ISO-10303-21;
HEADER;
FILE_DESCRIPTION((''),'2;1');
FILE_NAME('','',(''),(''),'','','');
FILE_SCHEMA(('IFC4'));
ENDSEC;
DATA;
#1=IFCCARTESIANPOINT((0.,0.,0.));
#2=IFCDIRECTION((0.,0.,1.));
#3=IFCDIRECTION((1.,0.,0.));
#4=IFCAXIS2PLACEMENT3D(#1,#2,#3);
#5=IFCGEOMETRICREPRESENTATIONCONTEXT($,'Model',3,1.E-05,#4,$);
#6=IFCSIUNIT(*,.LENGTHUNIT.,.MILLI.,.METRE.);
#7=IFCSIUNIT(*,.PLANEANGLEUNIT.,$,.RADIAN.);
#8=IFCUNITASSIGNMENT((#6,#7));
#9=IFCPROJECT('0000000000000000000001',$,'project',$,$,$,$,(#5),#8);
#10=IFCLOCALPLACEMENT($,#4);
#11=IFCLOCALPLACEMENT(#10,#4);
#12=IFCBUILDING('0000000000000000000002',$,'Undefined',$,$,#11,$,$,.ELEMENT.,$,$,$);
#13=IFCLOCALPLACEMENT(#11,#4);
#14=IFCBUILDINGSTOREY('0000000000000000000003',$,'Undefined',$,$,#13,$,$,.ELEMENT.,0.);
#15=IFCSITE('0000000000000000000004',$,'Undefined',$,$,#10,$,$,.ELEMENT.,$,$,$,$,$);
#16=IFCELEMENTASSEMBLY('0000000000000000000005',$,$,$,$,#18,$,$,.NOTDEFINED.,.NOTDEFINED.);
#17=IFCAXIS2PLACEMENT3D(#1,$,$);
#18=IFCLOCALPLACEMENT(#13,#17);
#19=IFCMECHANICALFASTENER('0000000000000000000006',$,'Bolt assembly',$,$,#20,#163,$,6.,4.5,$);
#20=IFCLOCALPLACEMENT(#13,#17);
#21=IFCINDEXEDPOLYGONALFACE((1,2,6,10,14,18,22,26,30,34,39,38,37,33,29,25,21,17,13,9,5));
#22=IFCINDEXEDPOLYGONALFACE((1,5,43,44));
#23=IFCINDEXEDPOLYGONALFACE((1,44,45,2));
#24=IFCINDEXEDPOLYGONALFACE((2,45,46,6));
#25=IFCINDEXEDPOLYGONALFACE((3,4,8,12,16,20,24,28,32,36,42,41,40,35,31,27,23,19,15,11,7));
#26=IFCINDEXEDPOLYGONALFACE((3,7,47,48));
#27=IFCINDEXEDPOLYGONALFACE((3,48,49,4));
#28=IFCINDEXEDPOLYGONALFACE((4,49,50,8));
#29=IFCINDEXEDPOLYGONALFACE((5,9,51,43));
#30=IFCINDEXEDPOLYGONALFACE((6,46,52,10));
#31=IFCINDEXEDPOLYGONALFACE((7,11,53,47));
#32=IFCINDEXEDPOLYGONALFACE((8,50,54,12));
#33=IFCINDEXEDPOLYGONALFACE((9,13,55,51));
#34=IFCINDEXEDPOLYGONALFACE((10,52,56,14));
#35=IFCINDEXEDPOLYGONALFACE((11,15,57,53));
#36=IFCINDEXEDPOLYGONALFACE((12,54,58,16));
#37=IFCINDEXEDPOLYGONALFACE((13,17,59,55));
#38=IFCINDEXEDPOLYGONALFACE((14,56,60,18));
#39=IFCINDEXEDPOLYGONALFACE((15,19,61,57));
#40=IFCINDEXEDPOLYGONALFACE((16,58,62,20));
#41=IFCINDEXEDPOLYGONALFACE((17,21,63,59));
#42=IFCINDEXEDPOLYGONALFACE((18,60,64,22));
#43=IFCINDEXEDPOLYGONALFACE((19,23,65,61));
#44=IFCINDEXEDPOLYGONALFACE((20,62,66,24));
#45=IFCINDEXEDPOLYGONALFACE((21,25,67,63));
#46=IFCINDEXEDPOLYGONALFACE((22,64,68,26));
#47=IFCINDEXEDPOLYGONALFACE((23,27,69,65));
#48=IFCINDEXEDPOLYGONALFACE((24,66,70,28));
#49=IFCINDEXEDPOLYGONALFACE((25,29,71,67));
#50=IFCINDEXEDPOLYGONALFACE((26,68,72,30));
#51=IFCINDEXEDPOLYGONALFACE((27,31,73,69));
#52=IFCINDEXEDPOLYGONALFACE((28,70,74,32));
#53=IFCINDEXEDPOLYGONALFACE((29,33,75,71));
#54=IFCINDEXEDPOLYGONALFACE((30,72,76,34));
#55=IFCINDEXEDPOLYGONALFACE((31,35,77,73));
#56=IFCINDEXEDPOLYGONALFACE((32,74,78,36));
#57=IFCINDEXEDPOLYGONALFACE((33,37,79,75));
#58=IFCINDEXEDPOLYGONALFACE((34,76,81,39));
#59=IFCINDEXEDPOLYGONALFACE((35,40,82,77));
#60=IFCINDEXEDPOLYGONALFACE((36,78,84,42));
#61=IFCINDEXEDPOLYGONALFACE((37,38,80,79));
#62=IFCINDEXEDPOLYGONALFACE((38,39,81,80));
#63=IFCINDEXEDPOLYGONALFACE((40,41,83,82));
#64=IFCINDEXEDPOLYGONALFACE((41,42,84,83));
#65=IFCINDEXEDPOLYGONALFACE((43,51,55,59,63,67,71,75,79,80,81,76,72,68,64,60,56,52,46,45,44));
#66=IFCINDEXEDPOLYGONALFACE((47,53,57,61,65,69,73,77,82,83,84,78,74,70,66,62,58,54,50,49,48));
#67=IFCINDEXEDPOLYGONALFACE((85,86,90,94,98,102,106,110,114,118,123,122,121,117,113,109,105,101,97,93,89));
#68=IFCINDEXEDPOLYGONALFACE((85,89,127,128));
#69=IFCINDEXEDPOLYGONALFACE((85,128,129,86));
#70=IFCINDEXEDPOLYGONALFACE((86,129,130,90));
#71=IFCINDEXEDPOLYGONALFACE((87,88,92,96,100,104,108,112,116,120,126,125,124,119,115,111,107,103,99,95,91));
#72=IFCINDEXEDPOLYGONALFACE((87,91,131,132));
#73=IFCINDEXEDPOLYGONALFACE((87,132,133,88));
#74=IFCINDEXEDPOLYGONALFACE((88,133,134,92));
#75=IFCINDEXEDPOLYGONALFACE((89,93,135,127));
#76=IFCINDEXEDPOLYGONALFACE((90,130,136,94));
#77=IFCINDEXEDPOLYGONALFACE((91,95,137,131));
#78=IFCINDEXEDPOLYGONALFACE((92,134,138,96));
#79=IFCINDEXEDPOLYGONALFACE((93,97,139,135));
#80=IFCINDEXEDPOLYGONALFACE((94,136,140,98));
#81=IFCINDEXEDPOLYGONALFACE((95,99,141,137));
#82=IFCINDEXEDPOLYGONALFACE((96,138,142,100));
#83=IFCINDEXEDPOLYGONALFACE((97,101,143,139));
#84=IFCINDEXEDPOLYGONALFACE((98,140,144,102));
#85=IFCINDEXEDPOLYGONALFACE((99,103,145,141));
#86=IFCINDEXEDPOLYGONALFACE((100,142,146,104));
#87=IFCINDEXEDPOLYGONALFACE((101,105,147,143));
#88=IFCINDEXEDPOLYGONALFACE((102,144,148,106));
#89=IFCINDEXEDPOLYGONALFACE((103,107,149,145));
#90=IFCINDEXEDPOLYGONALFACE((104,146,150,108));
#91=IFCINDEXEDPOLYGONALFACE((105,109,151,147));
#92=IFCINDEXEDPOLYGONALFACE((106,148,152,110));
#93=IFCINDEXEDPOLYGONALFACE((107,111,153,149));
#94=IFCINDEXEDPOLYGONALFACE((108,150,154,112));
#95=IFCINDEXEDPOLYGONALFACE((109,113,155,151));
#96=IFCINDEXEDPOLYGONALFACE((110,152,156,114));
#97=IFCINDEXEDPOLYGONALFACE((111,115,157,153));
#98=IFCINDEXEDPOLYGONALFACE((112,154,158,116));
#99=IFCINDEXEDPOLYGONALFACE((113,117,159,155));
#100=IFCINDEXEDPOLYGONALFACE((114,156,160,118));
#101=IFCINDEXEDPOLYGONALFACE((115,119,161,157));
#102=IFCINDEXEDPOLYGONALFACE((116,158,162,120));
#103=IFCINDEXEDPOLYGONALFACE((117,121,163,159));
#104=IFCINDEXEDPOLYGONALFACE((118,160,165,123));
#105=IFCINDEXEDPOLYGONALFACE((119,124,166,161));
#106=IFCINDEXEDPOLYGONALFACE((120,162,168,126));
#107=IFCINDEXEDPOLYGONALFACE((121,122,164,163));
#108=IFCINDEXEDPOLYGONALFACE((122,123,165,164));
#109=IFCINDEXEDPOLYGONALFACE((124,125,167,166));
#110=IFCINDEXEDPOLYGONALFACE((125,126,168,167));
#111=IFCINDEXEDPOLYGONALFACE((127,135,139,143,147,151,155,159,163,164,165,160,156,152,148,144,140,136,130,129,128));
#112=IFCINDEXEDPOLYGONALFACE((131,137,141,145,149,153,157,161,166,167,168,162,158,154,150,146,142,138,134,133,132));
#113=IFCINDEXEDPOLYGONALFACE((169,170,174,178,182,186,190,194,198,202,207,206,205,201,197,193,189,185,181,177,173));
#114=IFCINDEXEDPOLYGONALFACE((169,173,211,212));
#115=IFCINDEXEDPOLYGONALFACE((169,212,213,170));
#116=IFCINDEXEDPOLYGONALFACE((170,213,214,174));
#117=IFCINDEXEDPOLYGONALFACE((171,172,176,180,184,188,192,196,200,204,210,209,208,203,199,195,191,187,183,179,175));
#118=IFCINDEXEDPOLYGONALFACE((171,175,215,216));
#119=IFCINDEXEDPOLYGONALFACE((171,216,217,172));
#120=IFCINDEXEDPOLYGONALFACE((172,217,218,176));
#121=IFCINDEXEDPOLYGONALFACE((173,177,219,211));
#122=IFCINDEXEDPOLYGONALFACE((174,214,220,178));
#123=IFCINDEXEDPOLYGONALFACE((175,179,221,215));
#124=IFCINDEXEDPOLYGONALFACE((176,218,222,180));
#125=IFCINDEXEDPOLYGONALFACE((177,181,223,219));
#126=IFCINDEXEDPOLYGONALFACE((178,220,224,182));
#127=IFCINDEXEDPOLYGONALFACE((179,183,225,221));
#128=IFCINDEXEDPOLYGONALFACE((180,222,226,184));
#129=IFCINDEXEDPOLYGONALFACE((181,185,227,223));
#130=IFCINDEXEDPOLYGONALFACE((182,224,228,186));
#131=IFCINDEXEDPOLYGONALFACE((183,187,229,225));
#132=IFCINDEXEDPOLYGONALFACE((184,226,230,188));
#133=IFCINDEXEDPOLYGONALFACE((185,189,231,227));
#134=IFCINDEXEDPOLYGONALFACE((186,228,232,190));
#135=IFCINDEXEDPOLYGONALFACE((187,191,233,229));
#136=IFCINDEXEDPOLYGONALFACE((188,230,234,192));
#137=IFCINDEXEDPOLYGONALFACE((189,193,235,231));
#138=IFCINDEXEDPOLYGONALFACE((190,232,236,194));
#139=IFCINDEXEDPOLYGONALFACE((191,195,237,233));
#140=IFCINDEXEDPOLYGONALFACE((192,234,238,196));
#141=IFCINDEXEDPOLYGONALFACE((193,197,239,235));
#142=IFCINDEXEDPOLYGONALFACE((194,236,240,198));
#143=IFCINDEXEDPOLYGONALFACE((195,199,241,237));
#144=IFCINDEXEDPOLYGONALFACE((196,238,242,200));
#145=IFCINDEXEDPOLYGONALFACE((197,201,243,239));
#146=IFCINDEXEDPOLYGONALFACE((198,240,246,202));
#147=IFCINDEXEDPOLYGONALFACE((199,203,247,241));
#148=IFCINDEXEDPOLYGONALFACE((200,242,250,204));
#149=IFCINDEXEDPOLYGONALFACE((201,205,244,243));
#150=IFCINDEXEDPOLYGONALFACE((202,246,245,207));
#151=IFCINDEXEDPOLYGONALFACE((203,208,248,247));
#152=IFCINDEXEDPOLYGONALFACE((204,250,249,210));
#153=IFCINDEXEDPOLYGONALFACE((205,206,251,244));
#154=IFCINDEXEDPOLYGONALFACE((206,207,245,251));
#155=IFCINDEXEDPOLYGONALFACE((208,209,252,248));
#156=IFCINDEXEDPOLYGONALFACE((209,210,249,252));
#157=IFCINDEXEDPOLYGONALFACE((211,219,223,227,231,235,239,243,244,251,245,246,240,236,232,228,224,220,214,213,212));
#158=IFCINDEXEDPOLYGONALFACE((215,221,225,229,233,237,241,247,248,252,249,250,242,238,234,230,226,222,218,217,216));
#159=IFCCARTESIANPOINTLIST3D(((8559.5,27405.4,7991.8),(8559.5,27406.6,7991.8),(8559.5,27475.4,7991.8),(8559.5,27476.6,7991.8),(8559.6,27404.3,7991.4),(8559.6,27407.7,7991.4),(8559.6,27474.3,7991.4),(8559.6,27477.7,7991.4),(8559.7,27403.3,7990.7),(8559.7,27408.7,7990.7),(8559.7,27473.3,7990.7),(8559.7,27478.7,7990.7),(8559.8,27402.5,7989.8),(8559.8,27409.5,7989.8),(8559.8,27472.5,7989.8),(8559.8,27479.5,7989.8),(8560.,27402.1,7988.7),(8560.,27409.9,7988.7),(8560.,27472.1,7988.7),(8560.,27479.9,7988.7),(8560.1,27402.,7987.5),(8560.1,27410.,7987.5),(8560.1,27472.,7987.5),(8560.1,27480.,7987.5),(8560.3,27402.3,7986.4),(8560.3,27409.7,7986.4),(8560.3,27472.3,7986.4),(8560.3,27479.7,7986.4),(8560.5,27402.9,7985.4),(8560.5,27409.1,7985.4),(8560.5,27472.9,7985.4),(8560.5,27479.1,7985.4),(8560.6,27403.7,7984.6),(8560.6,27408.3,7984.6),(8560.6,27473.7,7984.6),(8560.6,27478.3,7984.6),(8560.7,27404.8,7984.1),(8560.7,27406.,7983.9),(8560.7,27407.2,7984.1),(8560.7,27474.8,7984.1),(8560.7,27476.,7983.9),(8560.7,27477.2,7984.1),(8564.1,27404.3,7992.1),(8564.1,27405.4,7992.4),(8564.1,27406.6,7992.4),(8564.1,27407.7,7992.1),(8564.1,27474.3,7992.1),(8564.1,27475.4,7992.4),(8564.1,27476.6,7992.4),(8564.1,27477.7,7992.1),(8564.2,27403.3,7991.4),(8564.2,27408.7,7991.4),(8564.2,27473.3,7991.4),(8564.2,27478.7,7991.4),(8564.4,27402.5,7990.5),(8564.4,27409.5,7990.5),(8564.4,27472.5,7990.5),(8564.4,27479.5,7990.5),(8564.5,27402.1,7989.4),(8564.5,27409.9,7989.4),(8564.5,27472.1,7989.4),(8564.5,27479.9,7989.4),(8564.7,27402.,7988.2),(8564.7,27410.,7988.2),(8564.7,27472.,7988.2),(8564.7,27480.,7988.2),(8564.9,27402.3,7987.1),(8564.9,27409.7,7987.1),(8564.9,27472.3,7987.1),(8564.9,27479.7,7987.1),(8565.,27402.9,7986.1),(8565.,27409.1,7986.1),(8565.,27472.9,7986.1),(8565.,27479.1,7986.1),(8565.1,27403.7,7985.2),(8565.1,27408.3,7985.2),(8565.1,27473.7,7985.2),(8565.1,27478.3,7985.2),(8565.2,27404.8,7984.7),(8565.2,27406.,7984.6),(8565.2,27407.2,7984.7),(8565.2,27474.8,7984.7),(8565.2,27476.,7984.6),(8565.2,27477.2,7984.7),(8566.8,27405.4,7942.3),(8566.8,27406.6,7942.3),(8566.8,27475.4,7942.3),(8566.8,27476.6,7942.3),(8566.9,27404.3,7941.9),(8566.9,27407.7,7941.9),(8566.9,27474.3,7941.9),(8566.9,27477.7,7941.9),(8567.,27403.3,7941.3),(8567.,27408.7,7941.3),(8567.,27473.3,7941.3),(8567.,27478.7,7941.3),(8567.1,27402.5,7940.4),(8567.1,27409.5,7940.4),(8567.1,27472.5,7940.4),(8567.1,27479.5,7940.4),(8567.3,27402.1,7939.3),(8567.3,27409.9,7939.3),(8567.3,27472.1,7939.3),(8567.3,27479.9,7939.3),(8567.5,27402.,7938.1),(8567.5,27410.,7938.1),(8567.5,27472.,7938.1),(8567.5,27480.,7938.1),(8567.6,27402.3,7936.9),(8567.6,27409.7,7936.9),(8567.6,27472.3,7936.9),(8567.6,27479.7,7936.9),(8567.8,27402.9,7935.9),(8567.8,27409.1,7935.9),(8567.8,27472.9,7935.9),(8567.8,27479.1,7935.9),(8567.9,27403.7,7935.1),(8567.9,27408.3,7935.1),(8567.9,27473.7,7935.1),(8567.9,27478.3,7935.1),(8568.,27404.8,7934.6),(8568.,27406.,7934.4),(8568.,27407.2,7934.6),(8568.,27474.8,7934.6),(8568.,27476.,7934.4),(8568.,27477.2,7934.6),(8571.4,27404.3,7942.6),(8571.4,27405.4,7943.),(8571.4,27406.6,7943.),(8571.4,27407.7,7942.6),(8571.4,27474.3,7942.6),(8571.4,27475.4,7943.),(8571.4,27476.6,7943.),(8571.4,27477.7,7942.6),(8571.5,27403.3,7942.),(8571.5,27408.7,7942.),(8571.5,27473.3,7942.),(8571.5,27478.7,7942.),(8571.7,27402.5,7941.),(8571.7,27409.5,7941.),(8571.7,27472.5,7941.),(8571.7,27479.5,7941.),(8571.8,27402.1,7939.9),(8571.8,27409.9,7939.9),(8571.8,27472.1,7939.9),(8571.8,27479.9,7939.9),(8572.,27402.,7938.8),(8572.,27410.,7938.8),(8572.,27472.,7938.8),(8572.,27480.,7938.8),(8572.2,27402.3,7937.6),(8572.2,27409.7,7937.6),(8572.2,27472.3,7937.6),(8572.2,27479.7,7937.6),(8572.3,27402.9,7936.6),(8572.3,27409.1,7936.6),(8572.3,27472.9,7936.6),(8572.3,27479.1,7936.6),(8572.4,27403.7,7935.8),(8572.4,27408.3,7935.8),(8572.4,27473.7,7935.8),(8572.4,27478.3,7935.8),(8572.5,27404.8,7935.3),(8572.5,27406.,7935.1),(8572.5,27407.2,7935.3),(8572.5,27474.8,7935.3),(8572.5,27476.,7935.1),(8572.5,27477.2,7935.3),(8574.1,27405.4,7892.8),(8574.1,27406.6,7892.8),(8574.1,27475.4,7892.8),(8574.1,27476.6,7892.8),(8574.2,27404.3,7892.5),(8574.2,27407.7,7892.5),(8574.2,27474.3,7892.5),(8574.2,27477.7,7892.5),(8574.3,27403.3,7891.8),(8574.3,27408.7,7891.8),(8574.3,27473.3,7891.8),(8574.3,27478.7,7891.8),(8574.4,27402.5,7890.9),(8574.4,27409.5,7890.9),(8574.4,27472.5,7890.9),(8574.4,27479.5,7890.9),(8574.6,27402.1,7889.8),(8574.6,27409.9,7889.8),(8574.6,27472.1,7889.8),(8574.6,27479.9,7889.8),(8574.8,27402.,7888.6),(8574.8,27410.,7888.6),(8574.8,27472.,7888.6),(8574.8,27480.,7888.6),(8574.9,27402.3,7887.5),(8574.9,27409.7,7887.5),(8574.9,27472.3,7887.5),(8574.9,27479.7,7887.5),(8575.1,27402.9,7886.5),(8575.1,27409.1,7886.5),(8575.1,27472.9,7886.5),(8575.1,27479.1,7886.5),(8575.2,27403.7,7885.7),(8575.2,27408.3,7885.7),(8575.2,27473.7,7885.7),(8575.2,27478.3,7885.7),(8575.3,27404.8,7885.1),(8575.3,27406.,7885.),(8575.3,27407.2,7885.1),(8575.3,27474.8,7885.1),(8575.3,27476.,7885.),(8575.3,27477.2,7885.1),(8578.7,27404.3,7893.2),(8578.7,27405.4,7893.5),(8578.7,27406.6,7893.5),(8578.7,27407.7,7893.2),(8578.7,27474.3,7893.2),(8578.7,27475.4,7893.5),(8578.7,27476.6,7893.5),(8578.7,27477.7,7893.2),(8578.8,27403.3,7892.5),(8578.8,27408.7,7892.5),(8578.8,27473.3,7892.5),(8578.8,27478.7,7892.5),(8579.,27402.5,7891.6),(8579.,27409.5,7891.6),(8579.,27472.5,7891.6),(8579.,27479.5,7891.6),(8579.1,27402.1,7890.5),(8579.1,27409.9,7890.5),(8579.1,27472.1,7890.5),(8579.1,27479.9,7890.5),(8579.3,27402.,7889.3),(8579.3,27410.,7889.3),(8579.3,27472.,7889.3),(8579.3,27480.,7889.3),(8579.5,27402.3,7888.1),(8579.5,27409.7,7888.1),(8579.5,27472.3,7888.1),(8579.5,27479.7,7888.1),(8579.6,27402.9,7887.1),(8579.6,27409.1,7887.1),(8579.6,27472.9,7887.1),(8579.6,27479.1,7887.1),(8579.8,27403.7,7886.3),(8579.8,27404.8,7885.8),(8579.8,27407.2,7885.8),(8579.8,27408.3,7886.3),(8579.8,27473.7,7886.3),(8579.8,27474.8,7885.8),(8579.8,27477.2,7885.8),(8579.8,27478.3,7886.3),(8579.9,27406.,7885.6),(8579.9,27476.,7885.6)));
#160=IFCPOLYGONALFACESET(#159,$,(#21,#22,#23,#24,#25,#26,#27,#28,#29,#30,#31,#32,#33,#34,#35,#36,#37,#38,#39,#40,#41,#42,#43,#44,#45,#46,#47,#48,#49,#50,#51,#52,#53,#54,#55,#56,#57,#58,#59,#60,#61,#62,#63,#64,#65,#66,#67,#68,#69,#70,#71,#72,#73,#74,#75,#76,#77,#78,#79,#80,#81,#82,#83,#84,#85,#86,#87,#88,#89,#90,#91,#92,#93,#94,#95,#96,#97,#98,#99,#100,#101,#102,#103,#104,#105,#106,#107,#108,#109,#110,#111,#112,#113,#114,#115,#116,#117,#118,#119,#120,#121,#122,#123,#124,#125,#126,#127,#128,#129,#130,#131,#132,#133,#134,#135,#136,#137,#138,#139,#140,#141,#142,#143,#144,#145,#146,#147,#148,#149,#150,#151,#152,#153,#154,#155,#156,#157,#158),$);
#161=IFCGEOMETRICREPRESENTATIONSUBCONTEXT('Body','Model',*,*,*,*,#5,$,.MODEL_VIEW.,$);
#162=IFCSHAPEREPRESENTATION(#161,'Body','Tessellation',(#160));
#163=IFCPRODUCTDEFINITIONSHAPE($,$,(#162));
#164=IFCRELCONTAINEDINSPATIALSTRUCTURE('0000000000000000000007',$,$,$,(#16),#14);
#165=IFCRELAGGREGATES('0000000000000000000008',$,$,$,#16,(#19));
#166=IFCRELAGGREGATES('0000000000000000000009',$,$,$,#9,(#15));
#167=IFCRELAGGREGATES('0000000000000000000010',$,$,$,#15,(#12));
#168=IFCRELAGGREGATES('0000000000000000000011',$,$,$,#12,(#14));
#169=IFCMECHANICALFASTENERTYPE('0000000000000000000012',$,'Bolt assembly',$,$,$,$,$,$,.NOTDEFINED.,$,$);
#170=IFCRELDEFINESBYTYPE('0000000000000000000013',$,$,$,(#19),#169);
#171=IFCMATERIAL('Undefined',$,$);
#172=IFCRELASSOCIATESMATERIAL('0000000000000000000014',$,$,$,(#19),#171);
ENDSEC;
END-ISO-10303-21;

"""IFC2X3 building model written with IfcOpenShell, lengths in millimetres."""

from ifc_helpers import new_model, si_unit, frame, origin_with_axes, origin_2d_with_axis, place, context, subcontext, project, spatial, circle, extrude, source, transform, mapped, material, type_object, element, aggregate, save


model = new_model("IFC2X3")

# Units and contexts
model_context = context("Model", 3, precision=1e-05, world=origin_with_axes())
body_context = subcontext(model_context, "Body", "Model", "MODEL_VIEW")
ifc_project = project(units=[si_unit("LENGTHUNIT", "METRE", prefix="MILLI"), si_unit("PLANEANGLEUNIT", "RADIAN")], contexts=[model_context])

# Site, building, storey
site_placement = place(None, origin_with_axes())
site = spatial("IfcSite", under=ifc_project, at=site_placement, Name="Undefined", CompositionType="ELEMENT")
building_placement = place(site_placement, origin_with_axes())
building = spatial("IfcBuilding", under=site, at=building_placement, Name="Undefined", CompositionType="ELEMENT")
storey_placement = place(building_placement, origin_with_axes())
storey = spatial("IfcBuildingStorey", under=building, at=storey_placement, Name="Undefined", CompositionType="ELEMENT", Elevation=0.0)

# Element assembly
assembly_1_placement = place(storey_placement, origin_with_axes())
assembly_1 = element("IfcElementAssembly", 1, at=assembly_1_placement, inside=storey, AssemblyPlace="NOTDEFINED", PredefinedType="NOTDEFINED")

# Mechanical fastener
ifc_material_1 = material(Name="Undefined")
mechanical_fastener_type = type_object("IfcMechanicalFastenerType", Name="Bolt assembly")
shared_shape_1 = source(origin_with_axes(), body_context, "Body", "SweptSolid", [
    extrude(circle(Radius=4.0, at=origin_2d_with_axis()), frame((0.0, 0.0, 0.0), z_axis=(0.0, 1.0, 0.0), x_axis=(1.0, 0.0, 0.0)), (0.0, 0.0, 1.0), 4.6),
])
mechanical_fastener_1_placement = place(assembly_1_placement, frame((8560.1, 27441.0, 7987.8), z_axis=(0.0, -1.0, 0.0), x_axis=(0.146203, 0.0, -0.989255)))
mechanical_fastener_1 = element("IfcMechanicalFastener", 2, at=mechanical_fastener_1_placement, type_object=mechanical_fastener_type, material=ifc_material_1, Name="Bolt assembly", NominalDiameter=6.0, NominalLength=4.5, context=body_context, shape_type="MappedRepresentation", body=[
    mapped(shared_shape_1, transform((0.0, 0.0, -35.0))),
    mapped(shared_shape_1, transform((50.0, 0.0, -35.0))),
    mapped(shared_shape_1, transform((100.0, 0.0, -35.0))),
    mapped(shared_shape_1, transform((0.0, 0.0, 35.0))),
    mapped(shared_shape_1, transform((50.0, 0.0, 35.0))),
    mapped(shared_shape_1, transform((100.0, 0.0, 35.0))),
])

aggregate(assembly_1, [mechanical_fastener_1])

save(model, "model.ifc")
